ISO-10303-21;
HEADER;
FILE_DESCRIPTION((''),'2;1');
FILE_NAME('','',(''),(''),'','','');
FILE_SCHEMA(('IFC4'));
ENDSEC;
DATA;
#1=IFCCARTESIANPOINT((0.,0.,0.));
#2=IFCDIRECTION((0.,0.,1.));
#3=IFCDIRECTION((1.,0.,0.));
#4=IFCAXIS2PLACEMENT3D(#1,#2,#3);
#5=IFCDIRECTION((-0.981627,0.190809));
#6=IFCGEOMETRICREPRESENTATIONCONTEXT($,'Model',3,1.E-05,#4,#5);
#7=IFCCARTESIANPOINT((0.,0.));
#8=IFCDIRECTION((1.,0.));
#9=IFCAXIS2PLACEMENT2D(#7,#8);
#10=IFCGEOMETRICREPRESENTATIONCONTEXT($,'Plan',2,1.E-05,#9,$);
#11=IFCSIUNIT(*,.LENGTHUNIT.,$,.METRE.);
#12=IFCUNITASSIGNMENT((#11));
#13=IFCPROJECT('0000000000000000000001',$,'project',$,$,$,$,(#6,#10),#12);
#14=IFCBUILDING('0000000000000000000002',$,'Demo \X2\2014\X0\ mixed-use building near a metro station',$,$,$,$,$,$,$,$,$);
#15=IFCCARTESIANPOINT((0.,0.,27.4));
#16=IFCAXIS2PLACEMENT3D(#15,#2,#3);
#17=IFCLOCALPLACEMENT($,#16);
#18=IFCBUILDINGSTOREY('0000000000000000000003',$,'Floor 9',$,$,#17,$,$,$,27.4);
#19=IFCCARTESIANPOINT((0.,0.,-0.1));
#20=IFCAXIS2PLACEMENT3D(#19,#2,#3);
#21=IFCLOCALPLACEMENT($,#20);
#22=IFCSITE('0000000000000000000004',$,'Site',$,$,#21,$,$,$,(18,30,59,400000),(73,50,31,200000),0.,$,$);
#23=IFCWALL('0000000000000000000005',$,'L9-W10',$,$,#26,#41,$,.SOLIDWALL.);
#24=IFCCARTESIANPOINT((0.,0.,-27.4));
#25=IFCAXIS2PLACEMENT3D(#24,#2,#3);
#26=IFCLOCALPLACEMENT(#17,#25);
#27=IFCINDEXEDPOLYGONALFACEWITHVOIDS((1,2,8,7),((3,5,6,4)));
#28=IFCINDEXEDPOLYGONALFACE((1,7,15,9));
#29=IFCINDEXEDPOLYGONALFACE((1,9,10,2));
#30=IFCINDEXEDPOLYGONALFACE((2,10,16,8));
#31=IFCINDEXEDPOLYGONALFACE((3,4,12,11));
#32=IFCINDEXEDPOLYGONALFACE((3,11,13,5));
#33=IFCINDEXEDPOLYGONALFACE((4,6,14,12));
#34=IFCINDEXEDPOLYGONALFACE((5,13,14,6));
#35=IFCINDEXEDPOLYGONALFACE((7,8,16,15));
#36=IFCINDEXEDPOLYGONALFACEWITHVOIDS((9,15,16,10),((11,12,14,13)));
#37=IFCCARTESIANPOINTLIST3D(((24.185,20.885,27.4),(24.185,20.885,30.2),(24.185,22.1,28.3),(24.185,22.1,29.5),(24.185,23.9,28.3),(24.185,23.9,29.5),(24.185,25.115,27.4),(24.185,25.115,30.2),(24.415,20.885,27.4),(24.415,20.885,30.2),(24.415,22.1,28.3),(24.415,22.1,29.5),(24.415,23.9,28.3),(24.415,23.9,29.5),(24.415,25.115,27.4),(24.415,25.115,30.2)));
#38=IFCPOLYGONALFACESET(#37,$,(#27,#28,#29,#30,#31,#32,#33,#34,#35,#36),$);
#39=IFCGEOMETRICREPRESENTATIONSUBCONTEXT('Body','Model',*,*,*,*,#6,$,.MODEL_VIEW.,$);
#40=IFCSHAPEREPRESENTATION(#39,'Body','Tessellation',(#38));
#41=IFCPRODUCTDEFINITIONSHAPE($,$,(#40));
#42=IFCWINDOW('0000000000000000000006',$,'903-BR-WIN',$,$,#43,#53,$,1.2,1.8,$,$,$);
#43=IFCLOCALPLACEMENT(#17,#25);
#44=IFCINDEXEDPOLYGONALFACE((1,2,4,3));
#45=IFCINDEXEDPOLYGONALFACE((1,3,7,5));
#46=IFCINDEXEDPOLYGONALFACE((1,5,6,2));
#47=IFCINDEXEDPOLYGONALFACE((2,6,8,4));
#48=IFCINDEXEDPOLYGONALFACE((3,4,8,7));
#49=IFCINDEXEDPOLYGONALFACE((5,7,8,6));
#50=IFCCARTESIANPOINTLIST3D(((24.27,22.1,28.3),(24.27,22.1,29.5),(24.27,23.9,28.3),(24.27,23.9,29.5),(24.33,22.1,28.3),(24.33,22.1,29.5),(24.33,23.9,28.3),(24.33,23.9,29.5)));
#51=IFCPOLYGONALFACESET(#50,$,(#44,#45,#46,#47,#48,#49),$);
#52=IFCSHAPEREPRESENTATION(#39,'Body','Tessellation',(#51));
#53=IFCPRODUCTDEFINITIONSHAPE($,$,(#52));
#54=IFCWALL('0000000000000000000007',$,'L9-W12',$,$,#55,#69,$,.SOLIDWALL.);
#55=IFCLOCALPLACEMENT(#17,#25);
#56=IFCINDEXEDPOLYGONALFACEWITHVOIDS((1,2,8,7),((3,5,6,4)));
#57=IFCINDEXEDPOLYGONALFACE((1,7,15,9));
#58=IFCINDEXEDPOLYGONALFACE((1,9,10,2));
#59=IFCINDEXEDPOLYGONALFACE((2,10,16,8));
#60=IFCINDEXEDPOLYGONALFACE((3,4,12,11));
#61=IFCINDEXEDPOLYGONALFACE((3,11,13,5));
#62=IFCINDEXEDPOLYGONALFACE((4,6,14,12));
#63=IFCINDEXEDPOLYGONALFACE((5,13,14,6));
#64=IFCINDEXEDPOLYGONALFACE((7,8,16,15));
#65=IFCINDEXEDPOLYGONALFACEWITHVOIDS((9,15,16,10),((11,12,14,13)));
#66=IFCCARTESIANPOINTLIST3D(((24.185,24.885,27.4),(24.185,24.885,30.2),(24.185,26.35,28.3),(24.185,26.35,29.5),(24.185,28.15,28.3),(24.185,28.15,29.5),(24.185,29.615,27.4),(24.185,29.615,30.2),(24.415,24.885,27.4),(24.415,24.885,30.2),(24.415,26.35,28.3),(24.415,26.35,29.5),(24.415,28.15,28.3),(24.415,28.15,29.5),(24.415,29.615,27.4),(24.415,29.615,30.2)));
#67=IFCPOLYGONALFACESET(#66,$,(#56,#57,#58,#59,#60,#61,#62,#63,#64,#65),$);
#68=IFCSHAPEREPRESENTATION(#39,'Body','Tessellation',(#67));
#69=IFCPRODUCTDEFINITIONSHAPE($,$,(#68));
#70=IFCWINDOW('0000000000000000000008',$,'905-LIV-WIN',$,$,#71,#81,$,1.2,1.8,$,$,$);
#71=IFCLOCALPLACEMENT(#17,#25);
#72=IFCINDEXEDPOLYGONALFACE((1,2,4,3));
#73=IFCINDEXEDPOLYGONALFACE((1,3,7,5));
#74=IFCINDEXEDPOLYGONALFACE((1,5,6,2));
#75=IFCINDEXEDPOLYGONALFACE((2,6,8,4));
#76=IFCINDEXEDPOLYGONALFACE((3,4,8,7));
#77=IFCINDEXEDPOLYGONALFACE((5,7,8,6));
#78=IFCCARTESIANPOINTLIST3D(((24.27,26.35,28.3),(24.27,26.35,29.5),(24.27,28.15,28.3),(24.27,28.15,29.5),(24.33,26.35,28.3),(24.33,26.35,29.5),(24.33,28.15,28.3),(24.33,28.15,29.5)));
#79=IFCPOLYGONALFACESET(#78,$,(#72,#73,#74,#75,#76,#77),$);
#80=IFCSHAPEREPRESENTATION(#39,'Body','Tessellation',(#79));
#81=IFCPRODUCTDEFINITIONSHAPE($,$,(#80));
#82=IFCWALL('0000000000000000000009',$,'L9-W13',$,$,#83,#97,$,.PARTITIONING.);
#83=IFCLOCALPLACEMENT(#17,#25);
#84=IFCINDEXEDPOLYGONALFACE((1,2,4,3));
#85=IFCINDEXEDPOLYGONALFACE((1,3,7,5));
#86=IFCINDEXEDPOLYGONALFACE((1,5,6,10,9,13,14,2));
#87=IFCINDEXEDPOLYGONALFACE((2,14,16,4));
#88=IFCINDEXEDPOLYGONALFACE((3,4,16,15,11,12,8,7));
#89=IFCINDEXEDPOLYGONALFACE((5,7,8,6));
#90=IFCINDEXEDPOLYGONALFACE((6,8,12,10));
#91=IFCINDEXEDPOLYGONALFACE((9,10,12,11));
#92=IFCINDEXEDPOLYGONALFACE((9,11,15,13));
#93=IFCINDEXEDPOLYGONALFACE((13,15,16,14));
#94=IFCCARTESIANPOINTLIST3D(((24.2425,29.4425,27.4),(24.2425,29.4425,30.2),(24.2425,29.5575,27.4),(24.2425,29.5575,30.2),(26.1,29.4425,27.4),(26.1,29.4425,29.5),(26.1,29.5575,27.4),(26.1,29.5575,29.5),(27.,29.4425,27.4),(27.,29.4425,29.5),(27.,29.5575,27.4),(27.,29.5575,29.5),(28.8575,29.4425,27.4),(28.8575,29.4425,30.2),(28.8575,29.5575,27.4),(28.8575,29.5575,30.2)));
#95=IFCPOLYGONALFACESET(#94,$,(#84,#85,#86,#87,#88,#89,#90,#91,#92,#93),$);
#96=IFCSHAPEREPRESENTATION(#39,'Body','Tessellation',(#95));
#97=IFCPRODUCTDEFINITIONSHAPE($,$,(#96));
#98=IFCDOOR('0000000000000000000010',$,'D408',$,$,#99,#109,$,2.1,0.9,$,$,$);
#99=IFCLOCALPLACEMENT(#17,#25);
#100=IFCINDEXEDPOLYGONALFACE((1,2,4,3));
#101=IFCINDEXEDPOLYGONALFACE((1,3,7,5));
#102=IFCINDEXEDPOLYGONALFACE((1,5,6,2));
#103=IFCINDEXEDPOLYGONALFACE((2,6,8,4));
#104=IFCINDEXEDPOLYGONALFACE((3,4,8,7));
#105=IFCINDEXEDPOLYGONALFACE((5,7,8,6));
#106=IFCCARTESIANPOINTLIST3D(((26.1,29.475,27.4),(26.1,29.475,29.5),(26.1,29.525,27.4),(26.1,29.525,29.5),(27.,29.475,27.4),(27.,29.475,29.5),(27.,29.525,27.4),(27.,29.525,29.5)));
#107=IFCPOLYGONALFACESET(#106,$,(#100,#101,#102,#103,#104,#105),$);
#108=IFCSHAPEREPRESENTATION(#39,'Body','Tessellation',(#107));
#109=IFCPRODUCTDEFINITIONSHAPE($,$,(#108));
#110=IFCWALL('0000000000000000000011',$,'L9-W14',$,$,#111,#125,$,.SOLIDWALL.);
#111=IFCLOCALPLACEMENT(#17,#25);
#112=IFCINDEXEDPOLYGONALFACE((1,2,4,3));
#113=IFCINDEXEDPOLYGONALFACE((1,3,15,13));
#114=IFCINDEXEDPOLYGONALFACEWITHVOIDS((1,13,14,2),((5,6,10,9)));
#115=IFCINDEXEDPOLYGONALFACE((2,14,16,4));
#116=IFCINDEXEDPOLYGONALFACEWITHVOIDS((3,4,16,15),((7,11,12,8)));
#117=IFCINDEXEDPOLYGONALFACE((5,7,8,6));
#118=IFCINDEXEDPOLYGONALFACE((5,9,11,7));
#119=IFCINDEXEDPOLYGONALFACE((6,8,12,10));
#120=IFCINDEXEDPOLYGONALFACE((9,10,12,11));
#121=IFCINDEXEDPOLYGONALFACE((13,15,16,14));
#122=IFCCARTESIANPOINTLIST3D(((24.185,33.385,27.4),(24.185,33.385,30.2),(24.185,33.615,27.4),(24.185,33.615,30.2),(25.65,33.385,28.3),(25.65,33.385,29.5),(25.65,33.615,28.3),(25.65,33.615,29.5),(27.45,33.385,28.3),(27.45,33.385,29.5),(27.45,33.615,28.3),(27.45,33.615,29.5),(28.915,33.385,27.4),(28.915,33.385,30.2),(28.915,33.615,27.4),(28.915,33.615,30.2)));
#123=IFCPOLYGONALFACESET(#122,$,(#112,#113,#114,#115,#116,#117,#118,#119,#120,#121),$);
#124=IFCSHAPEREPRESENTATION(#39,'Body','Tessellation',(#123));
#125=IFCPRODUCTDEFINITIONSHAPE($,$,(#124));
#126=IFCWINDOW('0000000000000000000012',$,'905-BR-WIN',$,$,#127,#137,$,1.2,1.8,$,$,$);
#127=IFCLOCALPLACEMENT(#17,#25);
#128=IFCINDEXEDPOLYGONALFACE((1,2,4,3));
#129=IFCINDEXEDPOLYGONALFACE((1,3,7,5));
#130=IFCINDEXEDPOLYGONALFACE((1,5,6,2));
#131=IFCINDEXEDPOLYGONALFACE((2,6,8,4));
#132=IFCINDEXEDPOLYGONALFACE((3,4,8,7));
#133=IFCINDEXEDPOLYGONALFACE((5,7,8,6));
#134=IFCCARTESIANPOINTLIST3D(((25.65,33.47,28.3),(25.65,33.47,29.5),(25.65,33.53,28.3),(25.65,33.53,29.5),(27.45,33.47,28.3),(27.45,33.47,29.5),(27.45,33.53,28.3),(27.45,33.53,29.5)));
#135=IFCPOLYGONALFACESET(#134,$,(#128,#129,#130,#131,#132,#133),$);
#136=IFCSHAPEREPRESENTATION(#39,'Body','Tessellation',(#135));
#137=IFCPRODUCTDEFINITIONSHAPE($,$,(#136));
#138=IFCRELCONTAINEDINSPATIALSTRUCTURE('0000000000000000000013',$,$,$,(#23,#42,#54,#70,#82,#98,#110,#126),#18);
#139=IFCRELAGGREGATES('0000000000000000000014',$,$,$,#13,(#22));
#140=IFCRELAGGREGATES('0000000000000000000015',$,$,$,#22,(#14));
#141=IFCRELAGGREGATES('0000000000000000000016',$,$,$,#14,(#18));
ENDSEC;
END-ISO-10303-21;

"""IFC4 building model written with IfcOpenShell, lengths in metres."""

from ifc_helpers import new_model, si_unit, direction, frame, origin_with_axes, origin_2d_with_axis, place, context, subcontext, project, spatial, line, indexed_curve, outline, extrude, element, fill, save


model = new_model("IFC4")

# Units and contexts
model_context = context("Model", 3, precision=1e-05, world=origin_with_axes(), true_north=direction((-0.981627, 0.190809)))
plan_context = context("Plan", 2, precision=1e-05, world=origin_2d_with_axis())
body_context = subcontext(model_context, "Body", "Model", "MODEL_VIEW")
ifc_project = project(units=[si_unit("LENGTHUNIT", "METRE")], contexts=[model_context, plan_context])

# Site, building, storey
site_placement = place(None, frame((0.0, 0.0, -0.1), z_axis=(0.0, 0.0, 1.0), x_axis=(1.0, 0.0, 0.0)))
site = spatial("IfcSite", under=ifc_project, at=site_placement, Name="Site", RefLatitude=(18, 30, 59, 400000), RefLongitude=(73, 50, 31, 200000), RefElevation=0.0)
building = spatial("IfcBuilding", under=site, Name="Demo — mixed-use building near a metro station")
storey_placement = place(None, frame((0.0, 0.0, 27.4), z_axis=(0.0, 0.0, 1.0), x_axis=(1.0, 0.0, 0.0)))
storey = spatial("IfcBuildingStorey", under=building, at=storey_placement, Name="Floor 9", Elevation=27.4)

# Wall, opening, window
wall_1_placement = place(storey_placement, frame((0.0, 0.0, -27.4), z_axis=(0.0, 0.0, 1.0), x_axis=(1.0, 0.0, 0.0)))
wall_1 = element("IfcWall", 1, at=wall_1_placement, inside=storey, Name="L9-W10", PredefinedType="SOLIDWALL", context=body_context, shape_type="SweptSolid", body=[
    extrude(outline(indexed_curve([(24.415, 25.115), (24.415, 20.885), (24.185, 20.885), (24.185, 25.115)], segments=[line(1, 2, 3, 4, 1)])), frame((0.0, 0.0, 27.4), z_axis=(0.0, 0.0, 1.0), x_axis=(1.0, 0.0, 0.0)), (0.0, 0.0, 1.0), 2.8),
])
opening_1_placement = place(wall_1_placement, origin_with_axes())
opening_1 = element("IfcOpeningElement", 2, at=opening_1_placement, cuts=wall_1, context=body_context, shape_type="SweptSolid", body=[
    extrude(outline(indexed_curve([(24.465, 23.9), (24.465, 22.1), (24.135, 22.1), (24.135, 23.9)], segments=[line(1, 2, 3, 4, 1)])), frame((0.0, 0.0, 28.3), z_axis=(0.0, 0.0, 1.0), x_axis=(1.0, 0.0, 0.0)), (0.0, 0.0, 1.0), 1.2),
])
window_1_placement = place(storey_placement, frame((0.0, 0.0, -27.4), z_axis=(0.0, 0.0, 1.0), x_axis=(1.0, 0.0, 0.0)))
window_1 = element("IfcWindow", 3, at=window_1_placement, inside=storey, Name="903-BR-WIN", OverallHeight=1.2, OverallWidth=1.8, context=body_context, shape_type="SweptSolid", body=[
    extrude(outline(indexed_curve([(24.33, 23.9), (24.33, 22.1), (24.27, 22.1), (24.27, 23.9)], segments=[line(1, 2, 3, 4, 1)])), frame((0.0, 0.0, 28.3), z_axis=(0.0, 0.0, 1.0), x_axis=(1.0, 0.0, 0.0)), (0.0, 0.0, 1.0), 1.2),
])
fill(opening_1, window_1)

# Wall, opening, window
wall_2_placement = place(storey_placement, frame((0.0, 0.0, -27.4), z_axis=(0.0, 0.0, 1.0), x_axis=(1.0, 0.0, 0.0)))
wall_2 = element("IfcWall", 4, at=wall_2_placement, inside=storey, Name="L9-W12", PredefinedType="SOLIDWALL", context=body_context, shape_type="SweptSolid", body=[
    extrude(outline(indexed_curve([(24.415, 29.615), (24.415, 24.885), (24.185, 24.885), (24.185, 29.615)], segments=[line(1, 2, 3, 4, 1)])), frame((0.0, 0.0, 27.4), z_axis=(0.0, 0.0, 1.0), x_axis=(1.0, 0.0, 0.0)), (0.0, 0.0, 1.0), 2.8),
])
opening_2_placement = place(wall_2_placement, origin_with_axes())
opening_2 = element("IfcOpeningElement", 5, at=opening_2_placement, cuts=wall_2, context=body_context, shape_type="SweptSolid", body=[
    extrude(outline(indexed_curve([(24.465, 28.15), (24.465, 26.35), (24.135, 26.35), (24.135, 28.15)], segments=[line(1, 2, 3, 4, 1)])), frame((0.0, 0.0, 28.3), z_axis=(0.0, 0.0, 1.0), x_axis=(1.0, 0.0, 0.0)), (0.0, 0.0, 1.0), 1.2),
])
window_2_placement = place(storey_placement, frame((0.0, 0.0, -27.4), z_axis=(0.0, 0.0, 1.0), x_axis=(1.0, 0.0, 0.0)))
window_2 = element("IfcWindow", 6, at=window_2_placement, inside=storey, Name="905-LIV-WIN", OverallHeight=1.2, OverallWidth=1.8, context=body_context, shape_type="SweptSolid", body=[
    extrude(outline(indexed_curve([(24.33, 28.15), (24.33, 26.35), (24.27, 26.35), (24.27, 28.15)], segments=[line(1, 2, 3, 4, 1)])), frame((0.0, 0.0, 28.3), z_axis=(0.0, 0.0, 1.0), x_axis=(1.0, 0.0, 0.0)), (0.0, 0.0, 1.0), 1.2),
])
fill(opening_2, window_2)

# Wall, opening, door
wall_3_placement = place(storey_placement, frame((0.0, 0.0, -27.4), z_axis=(0.0, 0.0, 1.0), x_axis=(1.0, 0.0, 0.0)))
wall_3 = element("IfcWall", 7, at=wall_3_placement, inside=storey, Name="L9-W13", PredefinedType="PARTITIONING", context=body_context, shape_type="SweptSolid", body=[
    extrude(outline(indexed_curve([(28.8575, 29.4425), (24.2425, 29.4425), (24.2425, 29.5575), (28.8575, 29.5575)], segments=[line(1, 2, 3, 4, 1)])), frame((0.0, 0.0, 27.4), z_axis=(0.0, 0.0, 1.0), x_axis=(1.0, 0.0, 0.0)), (0.0, 0.0, 1.0), 2.8),
])
opening_3_placement = place(wall_3_placement, origin_with_axes())
opening_3 = element("IfcOpeningElement", 8, at=opening_3_placement, cuts=wall_3, context=body_context, shape_type="SweptSolid", body=[
    extrude(outline(indexed_curve([(27.0, 29.3925), (26.1, 29.3925), (26.1, 29.6075), (27.0, 29.6075)], segments=[line(1, 2, 3, 4, 1)])), frame((0.0, 0.0, 27.4), z_axis=(0.0, 0.0, 1.0), x_axis=(1.0, 0.0, 0.0)), (0.0, 0.0, 1.0), 2.1),
])
door_1_placement = place(storey_placement, frame((0.0, 0.0, -27.4), z_axis=(0.0, 0.0, 1.0), x_axis=(1.0, 0.0, 0.0)))
door_1 = element("IfcDoor", 9, at=door_1_placement, inside=storey, Name="D408", OverallHeight=2.1, OverallWidth=0.9, context=body_context, shape_type="SweptSolid", body=[
    extrude(outline(indexed_curve([(27.0, 29.475), (26.1, 29.475), (26.1, 29.525), (27.0, 29.525)], segments=[line(1, 2, 3, 4, 1)])), frame((0.0, 0.0, 27.4), z_axis=(0.0, 0.0, 1.0), x_axis=(1.0, 0.0, 0.0)), (0.0, 0.0, 1.0), 2.1),
])
fill(opening_3, door_1)

# Wall, opening, window
wall_4_placement = place(storey_placement, frame((0.0, 0.0, -27.4), z_axis=(0.0, 0.0, 1.0), x_axis=(1.0, 0.0, 0.0)))
wall_4 = element("IfcWall", 10, at=wall_4_placement, inside=storey, Name="L9-W14", PredefinedType="SOLIDWALL", context=body_context, shape_type="SweptSolid", body=[
    extrude(outline(indexed_curve([(28.915, 33.385), (24.185, 33.385), (24.185, 33.615), (28.915, 33.615)], segments=[line(1, 2, 3, 4, 1)])), frame((0.0, 0.0, 27.4), z_axis=(0.0, 0.0, 1.0), x_axis=(1.0, 0.0, 0.0)), (0.0, 0.0, 1.0), 2.8),
])
opening_4_placement = place(wall_4_placement, origin_with_axes())
opening_4 = element("IfcOpeningElement", 11, at=opening_4_placement, cuts=wall_4, context=body_context, shape_type="SweptSolid", body=[
    extrude(outline(indexed_curve([(27.45, 33.335), (25.65, 33.335), (25.65, 33.665), (27.45, 33.665)], segments=[line(1, 2, 3, 4, 1)])), frame((0.0, 0.0, 28.3), z_axis=(0.0, 0.0, 1.0), x_axis=(1.0, 0.0, 0.0)), (0.0, 0.0, 1.0), 1.2),
])
window_3_placement = place(storey_placement, frame((0.0, 0.0, -27.4), z_axis=(0.0, 0.0, 1.0), x_axis=(1.0, 0.0, 0.0)))
window_3 = element("IfcWindow", 12, at=window_3_placement, inside=storey, Name="905-BR-WIN", OverallHeight=1.2, OverallWidth=1.8, context=body_context, shape_type="SweptSolid", body=[
    extrude(outline(indexed_curve([(27.45, 33.47), (25.65, 33.47), (25.65, 33.53), (27.45, 33.53)], segments=[line(1, 2, 3, 4, 1)])), frame((0.0, 0.0, 28.3), z_axis=(0.0, 0.0, 1.0), x_axis=(1.0, 0.0, 0.0)), (0.0, 0.0, 1.0), 1.2),
])
fill(opening_4, window_3)

save(model, "model.ifc")
